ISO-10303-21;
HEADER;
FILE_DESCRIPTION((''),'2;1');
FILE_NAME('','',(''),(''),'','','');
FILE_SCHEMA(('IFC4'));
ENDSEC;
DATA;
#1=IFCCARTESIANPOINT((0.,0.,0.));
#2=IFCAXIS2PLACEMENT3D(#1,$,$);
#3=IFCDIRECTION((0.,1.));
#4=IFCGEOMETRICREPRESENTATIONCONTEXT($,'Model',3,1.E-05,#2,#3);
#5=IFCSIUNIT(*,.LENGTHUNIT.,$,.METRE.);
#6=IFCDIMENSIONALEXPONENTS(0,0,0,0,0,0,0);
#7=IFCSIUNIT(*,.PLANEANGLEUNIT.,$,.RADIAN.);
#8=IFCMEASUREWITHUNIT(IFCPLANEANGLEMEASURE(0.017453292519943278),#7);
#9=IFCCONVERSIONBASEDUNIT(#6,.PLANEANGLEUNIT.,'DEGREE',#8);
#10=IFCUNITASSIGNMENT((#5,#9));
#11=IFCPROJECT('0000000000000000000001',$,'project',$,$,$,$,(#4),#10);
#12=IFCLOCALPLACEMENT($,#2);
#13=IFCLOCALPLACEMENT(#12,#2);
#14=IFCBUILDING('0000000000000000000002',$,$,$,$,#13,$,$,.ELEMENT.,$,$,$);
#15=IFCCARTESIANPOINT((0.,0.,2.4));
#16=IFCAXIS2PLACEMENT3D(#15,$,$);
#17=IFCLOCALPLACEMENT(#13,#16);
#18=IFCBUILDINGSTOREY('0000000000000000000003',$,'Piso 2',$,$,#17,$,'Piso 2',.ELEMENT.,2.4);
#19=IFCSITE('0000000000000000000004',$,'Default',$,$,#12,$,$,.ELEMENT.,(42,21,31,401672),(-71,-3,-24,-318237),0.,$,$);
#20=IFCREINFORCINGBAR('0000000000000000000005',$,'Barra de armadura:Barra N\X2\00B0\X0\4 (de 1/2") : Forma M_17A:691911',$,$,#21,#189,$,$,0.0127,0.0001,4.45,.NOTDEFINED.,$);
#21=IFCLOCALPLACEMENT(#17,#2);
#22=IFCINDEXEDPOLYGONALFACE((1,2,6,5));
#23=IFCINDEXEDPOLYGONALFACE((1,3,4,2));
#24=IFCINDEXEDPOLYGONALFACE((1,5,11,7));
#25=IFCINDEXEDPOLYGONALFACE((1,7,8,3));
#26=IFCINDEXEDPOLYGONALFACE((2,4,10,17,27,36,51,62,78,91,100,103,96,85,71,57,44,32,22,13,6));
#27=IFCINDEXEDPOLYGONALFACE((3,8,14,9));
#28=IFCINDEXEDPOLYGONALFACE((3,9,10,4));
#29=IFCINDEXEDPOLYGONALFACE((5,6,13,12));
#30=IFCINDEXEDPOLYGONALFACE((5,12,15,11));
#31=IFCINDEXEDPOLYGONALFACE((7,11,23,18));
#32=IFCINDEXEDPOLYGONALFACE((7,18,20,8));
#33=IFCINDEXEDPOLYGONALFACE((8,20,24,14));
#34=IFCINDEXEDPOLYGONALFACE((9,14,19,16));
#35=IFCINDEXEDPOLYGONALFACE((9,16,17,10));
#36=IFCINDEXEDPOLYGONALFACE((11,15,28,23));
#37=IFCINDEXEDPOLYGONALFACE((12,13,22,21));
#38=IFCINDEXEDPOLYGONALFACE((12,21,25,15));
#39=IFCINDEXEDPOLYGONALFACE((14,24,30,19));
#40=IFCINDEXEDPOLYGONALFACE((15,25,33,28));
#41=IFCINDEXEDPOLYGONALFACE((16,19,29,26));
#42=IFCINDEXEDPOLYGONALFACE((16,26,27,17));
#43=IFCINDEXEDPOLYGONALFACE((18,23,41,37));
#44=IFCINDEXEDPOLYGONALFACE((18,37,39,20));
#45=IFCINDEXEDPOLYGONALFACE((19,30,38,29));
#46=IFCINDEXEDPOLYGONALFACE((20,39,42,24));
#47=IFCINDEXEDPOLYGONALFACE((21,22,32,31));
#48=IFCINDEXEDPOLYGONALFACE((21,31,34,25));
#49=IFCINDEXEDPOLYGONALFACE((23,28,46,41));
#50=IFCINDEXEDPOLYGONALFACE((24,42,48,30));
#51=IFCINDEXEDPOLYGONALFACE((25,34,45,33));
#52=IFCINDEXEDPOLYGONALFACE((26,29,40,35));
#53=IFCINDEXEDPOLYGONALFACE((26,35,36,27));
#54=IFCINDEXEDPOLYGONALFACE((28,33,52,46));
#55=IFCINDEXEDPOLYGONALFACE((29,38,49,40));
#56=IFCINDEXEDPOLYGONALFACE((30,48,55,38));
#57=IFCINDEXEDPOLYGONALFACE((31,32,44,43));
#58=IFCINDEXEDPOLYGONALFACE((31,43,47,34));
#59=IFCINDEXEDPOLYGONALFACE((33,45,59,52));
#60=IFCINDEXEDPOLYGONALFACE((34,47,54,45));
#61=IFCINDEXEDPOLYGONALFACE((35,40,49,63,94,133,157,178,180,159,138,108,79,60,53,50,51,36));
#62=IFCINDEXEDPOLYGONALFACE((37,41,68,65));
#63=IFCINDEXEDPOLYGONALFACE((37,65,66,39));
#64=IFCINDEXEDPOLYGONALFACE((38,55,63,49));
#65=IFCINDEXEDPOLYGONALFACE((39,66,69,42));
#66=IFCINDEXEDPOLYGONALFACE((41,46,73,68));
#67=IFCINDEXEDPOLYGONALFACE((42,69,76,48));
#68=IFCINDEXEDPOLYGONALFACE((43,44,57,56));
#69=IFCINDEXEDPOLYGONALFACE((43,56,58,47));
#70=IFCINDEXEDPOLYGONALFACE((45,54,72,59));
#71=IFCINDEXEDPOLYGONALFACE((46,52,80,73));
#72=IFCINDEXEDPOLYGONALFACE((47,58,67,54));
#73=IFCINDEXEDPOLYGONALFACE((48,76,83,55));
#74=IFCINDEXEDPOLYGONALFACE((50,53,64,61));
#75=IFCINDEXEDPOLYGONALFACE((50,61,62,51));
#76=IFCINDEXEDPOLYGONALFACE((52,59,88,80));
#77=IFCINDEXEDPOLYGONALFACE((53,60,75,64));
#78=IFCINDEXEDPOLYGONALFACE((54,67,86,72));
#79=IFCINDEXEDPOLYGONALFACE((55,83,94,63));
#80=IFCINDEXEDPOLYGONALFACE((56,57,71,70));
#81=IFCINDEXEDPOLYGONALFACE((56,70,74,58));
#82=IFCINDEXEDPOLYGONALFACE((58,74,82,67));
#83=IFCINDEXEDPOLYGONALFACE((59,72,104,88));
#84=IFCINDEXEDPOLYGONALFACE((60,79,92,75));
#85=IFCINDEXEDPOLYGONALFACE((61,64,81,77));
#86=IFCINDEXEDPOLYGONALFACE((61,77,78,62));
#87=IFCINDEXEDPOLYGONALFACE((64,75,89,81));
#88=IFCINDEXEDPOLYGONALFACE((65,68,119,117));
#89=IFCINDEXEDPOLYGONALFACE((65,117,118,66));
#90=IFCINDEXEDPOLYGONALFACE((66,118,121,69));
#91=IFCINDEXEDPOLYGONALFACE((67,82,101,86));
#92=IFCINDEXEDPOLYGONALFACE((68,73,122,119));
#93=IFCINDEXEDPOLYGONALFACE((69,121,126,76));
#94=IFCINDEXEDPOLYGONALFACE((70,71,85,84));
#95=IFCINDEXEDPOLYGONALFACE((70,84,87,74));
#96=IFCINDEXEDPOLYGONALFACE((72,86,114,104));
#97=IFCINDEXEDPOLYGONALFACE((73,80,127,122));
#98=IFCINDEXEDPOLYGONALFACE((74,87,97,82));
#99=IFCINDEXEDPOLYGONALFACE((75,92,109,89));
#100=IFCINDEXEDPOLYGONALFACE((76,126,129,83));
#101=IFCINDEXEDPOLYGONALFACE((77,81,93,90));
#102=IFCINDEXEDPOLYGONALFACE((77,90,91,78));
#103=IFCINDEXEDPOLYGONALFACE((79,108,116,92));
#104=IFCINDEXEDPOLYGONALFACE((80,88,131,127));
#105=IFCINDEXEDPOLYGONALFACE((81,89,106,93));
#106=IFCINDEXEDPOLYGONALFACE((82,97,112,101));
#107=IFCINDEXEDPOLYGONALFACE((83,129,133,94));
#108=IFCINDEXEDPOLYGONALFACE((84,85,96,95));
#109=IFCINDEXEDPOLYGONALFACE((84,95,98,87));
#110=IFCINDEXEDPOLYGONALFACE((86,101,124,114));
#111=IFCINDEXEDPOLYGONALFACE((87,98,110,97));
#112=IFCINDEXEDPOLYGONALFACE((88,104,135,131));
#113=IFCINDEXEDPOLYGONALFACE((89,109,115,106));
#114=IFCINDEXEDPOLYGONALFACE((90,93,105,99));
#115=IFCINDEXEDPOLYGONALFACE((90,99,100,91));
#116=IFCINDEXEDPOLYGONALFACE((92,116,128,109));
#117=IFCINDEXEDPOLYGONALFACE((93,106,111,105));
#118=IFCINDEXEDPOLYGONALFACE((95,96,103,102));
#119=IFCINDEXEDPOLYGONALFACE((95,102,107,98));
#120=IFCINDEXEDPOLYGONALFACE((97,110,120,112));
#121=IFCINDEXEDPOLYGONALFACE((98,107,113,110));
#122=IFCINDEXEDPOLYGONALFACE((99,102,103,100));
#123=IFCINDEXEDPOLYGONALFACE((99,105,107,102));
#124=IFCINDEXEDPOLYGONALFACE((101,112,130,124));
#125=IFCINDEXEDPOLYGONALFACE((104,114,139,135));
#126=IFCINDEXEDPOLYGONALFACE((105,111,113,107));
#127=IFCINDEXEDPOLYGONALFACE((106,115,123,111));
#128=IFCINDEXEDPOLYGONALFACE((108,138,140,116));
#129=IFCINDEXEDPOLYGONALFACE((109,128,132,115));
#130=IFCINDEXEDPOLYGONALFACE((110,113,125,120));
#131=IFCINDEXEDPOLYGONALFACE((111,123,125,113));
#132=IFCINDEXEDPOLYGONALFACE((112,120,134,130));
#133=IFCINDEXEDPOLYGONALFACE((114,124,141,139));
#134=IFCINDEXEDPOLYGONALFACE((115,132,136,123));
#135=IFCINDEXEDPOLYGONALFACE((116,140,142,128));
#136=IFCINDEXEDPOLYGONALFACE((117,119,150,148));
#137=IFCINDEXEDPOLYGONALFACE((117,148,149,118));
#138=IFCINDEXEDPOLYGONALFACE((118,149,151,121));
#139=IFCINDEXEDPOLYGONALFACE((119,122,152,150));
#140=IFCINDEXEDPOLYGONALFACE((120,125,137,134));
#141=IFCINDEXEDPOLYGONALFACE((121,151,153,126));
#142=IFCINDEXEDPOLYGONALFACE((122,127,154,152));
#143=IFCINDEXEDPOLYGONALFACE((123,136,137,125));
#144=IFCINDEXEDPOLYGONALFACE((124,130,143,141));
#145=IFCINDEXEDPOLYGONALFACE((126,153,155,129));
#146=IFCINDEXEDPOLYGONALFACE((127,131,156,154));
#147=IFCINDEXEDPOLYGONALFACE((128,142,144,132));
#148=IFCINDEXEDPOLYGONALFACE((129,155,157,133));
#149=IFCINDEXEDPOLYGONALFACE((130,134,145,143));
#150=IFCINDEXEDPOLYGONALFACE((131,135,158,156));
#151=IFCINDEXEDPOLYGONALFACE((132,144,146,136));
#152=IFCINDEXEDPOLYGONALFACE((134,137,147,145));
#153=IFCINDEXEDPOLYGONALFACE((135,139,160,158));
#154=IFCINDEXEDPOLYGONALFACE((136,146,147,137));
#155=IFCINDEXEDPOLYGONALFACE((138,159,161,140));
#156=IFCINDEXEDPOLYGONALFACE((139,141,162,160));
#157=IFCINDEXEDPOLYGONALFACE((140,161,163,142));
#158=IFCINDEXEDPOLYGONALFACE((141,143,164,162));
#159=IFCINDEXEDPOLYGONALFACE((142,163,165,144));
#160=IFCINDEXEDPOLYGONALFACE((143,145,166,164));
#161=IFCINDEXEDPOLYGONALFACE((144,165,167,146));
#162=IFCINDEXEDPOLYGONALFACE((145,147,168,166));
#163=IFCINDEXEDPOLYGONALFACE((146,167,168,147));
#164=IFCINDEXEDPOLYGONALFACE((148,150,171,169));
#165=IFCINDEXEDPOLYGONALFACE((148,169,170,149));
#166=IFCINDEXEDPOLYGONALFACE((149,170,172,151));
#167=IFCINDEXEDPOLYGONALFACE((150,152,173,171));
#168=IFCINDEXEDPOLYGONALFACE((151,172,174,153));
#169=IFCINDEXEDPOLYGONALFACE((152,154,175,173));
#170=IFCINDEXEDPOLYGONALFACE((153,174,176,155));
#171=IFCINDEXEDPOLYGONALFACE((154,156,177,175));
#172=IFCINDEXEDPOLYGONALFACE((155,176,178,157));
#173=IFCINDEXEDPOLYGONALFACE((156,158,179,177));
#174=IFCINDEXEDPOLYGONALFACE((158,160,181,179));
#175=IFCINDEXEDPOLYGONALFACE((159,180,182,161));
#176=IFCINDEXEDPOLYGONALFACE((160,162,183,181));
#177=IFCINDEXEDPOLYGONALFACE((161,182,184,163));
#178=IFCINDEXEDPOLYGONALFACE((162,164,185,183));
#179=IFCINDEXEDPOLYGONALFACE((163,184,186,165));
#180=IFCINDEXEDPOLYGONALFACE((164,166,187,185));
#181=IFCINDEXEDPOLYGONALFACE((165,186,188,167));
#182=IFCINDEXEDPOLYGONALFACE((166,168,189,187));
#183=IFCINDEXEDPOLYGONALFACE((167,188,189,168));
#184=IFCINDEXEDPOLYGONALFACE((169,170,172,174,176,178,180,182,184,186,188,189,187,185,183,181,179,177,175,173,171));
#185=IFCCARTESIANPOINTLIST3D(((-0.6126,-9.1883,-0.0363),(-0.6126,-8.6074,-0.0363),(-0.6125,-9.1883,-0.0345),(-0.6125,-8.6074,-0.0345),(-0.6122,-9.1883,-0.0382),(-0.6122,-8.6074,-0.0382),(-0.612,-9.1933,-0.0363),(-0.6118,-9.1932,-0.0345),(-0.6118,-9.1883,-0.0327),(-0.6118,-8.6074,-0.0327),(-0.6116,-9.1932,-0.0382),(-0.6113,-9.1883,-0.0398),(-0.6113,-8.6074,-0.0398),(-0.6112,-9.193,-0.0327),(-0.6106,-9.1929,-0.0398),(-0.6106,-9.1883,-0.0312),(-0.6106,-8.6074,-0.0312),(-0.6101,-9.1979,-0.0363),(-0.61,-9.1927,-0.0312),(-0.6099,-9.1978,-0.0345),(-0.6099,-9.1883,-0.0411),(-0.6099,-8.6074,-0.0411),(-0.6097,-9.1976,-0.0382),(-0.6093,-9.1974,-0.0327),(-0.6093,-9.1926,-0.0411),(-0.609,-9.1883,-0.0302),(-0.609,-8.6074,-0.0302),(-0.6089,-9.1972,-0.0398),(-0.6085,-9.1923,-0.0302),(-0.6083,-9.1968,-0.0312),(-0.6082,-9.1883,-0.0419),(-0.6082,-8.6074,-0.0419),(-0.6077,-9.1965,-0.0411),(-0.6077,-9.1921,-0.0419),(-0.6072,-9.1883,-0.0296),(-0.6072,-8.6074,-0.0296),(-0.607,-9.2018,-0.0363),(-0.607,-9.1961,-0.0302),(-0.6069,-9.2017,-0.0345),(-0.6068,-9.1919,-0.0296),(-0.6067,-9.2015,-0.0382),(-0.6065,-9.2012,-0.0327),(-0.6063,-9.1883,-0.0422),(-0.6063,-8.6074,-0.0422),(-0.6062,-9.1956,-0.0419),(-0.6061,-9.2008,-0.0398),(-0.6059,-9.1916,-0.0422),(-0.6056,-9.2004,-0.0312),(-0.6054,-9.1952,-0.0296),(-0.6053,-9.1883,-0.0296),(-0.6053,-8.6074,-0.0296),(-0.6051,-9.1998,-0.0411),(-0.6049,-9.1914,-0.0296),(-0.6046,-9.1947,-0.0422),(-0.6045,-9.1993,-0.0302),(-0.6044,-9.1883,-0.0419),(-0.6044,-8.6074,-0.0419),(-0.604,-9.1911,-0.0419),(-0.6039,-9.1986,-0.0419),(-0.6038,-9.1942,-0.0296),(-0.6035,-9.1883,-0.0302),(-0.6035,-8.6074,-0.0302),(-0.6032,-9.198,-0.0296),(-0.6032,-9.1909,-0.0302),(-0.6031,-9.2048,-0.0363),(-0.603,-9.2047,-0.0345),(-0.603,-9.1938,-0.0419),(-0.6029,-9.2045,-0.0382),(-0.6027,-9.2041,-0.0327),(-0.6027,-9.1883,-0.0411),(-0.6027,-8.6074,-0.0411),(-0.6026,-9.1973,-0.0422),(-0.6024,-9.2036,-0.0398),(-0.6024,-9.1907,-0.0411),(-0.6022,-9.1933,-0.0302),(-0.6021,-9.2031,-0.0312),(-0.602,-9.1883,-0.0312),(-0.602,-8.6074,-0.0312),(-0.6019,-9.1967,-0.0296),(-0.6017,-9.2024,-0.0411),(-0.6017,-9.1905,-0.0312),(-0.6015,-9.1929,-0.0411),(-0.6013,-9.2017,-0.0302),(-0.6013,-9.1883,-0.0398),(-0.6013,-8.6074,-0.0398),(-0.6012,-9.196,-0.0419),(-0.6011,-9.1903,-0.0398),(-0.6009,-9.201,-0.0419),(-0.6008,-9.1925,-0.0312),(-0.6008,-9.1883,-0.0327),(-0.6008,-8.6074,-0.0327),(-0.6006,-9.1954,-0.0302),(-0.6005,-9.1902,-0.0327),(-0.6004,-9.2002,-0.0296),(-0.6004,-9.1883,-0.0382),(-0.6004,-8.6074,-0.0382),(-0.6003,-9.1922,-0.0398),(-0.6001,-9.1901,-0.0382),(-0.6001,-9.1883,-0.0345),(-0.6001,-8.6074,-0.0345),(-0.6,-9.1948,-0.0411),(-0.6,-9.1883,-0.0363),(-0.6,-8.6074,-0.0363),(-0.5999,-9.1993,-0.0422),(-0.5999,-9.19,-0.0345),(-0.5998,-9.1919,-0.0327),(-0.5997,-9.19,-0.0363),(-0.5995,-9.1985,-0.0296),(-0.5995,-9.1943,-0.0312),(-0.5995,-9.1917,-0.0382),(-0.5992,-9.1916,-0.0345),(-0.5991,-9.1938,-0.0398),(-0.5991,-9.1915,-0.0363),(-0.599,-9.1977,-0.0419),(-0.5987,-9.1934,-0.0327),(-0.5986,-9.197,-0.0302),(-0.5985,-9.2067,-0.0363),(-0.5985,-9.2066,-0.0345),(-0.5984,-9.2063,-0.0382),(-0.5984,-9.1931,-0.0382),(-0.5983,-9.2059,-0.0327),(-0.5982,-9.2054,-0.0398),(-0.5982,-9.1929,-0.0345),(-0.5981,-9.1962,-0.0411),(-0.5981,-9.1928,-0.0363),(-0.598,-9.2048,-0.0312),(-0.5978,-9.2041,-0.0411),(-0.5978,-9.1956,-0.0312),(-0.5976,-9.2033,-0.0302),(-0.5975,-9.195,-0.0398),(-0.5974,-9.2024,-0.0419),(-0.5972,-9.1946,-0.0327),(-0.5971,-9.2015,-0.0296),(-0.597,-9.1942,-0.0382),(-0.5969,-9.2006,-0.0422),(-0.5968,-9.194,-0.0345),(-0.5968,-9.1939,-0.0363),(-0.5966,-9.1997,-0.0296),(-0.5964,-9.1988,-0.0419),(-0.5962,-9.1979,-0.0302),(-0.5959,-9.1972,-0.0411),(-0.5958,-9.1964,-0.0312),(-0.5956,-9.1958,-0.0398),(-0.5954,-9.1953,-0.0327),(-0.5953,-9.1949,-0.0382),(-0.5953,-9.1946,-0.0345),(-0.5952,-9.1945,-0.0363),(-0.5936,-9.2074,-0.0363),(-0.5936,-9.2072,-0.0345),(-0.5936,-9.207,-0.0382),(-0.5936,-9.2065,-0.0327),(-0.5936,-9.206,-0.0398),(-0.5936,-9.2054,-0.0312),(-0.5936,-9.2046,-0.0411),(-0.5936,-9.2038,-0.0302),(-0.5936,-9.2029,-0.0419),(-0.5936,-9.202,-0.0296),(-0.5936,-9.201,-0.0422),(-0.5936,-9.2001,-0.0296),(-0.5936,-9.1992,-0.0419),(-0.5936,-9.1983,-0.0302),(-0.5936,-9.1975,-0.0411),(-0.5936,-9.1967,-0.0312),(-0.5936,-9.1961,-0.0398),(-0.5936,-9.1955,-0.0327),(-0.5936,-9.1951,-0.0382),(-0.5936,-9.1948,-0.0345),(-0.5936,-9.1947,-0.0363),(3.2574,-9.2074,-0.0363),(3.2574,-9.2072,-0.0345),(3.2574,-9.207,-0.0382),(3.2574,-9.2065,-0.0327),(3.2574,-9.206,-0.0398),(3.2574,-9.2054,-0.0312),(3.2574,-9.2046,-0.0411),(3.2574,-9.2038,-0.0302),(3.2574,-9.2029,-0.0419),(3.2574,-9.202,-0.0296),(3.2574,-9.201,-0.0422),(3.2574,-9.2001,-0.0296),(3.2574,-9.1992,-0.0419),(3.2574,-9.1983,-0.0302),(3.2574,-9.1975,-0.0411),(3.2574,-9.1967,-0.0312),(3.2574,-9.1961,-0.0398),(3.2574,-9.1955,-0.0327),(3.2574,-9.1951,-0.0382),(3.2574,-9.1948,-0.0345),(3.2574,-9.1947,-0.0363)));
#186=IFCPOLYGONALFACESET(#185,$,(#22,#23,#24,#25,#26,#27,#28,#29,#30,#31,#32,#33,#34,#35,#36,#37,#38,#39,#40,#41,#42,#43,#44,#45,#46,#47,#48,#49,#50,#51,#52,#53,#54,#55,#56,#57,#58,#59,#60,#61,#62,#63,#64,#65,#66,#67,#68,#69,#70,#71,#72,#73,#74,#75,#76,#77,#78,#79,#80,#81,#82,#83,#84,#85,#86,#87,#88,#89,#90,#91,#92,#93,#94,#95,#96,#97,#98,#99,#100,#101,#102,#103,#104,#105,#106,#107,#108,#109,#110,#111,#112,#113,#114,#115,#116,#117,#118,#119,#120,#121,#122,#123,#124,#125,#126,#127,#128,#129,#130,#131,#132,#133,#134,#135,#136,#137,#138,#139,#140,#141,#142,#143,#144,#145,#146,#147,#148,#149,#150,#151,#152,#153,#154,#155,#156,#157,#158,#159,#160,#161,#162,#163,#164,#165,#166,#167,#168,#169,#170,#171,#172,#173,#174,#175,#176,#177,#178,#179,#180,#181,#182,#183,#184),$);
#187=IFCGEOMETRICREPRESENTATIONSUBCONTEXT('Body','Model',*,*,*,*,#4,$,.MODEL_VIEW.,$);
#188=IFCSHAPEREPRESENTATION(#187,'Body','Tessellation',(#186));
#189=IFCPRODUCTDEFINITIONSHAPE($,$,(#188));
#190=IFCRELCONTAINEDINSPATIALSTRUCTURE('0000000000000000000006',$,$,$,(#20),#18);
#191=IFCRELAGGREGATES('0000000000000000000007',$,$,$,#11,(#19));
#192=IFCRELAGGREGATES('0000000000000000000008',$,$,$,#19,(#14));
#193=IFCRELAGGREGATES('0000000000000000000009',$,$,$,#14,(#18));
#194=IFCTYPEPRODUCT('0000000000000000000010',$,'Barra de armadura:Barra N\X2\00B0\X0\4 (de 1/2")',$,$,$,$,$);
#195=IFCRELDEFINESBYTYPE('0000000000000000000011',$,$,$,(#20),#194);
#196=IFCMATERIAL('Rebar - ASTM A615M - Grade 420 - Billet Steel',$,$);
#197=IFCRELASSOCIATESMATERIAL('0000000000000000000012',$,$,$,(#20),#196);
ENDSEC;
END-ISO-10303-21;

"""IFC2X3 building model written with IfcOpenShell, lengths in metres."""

from ifc_helpers import new_model, entity, si_unit, converted_unit, direction, frame, origin, place, context, subcontext, project, spatial, material, type_object, element, save


model = new_model("IFC2X3")

# Units and contexts
model_context = context("Model", 3, precision=1e-05, world=origin(), true_north=direction((0.0, 1.0)))
body_context = subcontext(model_context, "Body", "Model", "MODEL_VIEW")
ifc_project = project(units=[si_unit("LENGTHUNIT", "METRE"), converted_unit("PLANEANGLEUNIT", "DEGREE", entity("IfcPlaneAngleMeasure", 0.017453292519943278), si_unit("PLANEANGLEUNIT", "RADIAN"), dimensions=[0, 0, 0, 0, 0, 0, 0])], contexts=[model_context])

# Site, building, storey
site_placement = place(None, origin())
site = spatial("IfcSite", under=ifc_project, at=site_placement, Name="Default", CompositionType="ELEMENT", RefLatitude=(42, 21, 31, 401672), RefLongitude=(-71, -3, -24, -318237), RefElevation=0.0)
building_placement = place(site_placement, origin())
building = spatial("IfcBuilding", under=site, at=building_placement, CompositionType="ELEMENT")
storey_placement = place(building_placement, frame((0.0, 0.0, 2.4)))
storey = spatial("IfcBuildingStorey", under=building, at=storey_placement, Name="Piso 2", LongName="Piso 2", CompositionType="ELEMENT", Elevation=2.4)

# Reinforcing bar
ifc_material_1 = material(Name="Rebar - ASTM A615M - Grade 420 - Billet Steel")
type_product_1 = type_object("IfcTypeProduct", Name="Barra de armadura:Barra N°4 (de 1/2\")")
reinforcing_bar_1_placement = place(storey_placement, origin())
element("IfcReinforcingBar", 1, at=reinforcing_bar_1_placement, inside=storey, type_object=type_product_1, material=ifc_material_1, Name="Barra de armadura:Barra N°4 (de 1/2\") : Forma M_17A:691911", BarLength=4.45, BarRole="NOTDEFINED", CrossSectionArea=0.0001, NominalDiameter=0.0127, context=body_context, shape_type="AdvancedSweptSolid", body=[
    entity("IfcSweptDiskSolid", entity("IfcCompositeCurve", [entity("IfcCompositeCurveSegment", "CONTINUOUS", True, entity("IfcPolyline", [entity("IfcCartesianPoint", [3.2574, -9.201, -0.0359]), entity("IfcCartesianPoint", [-0.5936, -9.201, -0.0359])])), entity("IfcCompositeCurveSegment", "CONTINUOUS", True, entity("IfcTrimmedCurve", entity("IfcCircle", entity("IfcAxis2Placement3D", entity("IfcCartesianPoint", [-0.5936, -9.1883, -0.0359]), entity("IfcDirection", [0.0, 0.0, -1.0]), entity("IfcDirection", [-1.0, 0.0, 0.0])), 0.0127), [entity("IfcParameterValue", 270.0)], [entity("IfcParameterValue", 360.0)], True, "PARAMETER")), entity("IfcCompositeCurveSegment", "CONTINUOUS", True, entity("IfcPolyline", [entity("IfcCartesianPoint", [-0.6063, -9.1883, -0.0359]), entity("IfcCartesianPoint", [-0.6063, -8.6074, -0.0359])]))], False), 0.0063, None, 0.0, 92.0),
])

save(model, "model.ifc")
